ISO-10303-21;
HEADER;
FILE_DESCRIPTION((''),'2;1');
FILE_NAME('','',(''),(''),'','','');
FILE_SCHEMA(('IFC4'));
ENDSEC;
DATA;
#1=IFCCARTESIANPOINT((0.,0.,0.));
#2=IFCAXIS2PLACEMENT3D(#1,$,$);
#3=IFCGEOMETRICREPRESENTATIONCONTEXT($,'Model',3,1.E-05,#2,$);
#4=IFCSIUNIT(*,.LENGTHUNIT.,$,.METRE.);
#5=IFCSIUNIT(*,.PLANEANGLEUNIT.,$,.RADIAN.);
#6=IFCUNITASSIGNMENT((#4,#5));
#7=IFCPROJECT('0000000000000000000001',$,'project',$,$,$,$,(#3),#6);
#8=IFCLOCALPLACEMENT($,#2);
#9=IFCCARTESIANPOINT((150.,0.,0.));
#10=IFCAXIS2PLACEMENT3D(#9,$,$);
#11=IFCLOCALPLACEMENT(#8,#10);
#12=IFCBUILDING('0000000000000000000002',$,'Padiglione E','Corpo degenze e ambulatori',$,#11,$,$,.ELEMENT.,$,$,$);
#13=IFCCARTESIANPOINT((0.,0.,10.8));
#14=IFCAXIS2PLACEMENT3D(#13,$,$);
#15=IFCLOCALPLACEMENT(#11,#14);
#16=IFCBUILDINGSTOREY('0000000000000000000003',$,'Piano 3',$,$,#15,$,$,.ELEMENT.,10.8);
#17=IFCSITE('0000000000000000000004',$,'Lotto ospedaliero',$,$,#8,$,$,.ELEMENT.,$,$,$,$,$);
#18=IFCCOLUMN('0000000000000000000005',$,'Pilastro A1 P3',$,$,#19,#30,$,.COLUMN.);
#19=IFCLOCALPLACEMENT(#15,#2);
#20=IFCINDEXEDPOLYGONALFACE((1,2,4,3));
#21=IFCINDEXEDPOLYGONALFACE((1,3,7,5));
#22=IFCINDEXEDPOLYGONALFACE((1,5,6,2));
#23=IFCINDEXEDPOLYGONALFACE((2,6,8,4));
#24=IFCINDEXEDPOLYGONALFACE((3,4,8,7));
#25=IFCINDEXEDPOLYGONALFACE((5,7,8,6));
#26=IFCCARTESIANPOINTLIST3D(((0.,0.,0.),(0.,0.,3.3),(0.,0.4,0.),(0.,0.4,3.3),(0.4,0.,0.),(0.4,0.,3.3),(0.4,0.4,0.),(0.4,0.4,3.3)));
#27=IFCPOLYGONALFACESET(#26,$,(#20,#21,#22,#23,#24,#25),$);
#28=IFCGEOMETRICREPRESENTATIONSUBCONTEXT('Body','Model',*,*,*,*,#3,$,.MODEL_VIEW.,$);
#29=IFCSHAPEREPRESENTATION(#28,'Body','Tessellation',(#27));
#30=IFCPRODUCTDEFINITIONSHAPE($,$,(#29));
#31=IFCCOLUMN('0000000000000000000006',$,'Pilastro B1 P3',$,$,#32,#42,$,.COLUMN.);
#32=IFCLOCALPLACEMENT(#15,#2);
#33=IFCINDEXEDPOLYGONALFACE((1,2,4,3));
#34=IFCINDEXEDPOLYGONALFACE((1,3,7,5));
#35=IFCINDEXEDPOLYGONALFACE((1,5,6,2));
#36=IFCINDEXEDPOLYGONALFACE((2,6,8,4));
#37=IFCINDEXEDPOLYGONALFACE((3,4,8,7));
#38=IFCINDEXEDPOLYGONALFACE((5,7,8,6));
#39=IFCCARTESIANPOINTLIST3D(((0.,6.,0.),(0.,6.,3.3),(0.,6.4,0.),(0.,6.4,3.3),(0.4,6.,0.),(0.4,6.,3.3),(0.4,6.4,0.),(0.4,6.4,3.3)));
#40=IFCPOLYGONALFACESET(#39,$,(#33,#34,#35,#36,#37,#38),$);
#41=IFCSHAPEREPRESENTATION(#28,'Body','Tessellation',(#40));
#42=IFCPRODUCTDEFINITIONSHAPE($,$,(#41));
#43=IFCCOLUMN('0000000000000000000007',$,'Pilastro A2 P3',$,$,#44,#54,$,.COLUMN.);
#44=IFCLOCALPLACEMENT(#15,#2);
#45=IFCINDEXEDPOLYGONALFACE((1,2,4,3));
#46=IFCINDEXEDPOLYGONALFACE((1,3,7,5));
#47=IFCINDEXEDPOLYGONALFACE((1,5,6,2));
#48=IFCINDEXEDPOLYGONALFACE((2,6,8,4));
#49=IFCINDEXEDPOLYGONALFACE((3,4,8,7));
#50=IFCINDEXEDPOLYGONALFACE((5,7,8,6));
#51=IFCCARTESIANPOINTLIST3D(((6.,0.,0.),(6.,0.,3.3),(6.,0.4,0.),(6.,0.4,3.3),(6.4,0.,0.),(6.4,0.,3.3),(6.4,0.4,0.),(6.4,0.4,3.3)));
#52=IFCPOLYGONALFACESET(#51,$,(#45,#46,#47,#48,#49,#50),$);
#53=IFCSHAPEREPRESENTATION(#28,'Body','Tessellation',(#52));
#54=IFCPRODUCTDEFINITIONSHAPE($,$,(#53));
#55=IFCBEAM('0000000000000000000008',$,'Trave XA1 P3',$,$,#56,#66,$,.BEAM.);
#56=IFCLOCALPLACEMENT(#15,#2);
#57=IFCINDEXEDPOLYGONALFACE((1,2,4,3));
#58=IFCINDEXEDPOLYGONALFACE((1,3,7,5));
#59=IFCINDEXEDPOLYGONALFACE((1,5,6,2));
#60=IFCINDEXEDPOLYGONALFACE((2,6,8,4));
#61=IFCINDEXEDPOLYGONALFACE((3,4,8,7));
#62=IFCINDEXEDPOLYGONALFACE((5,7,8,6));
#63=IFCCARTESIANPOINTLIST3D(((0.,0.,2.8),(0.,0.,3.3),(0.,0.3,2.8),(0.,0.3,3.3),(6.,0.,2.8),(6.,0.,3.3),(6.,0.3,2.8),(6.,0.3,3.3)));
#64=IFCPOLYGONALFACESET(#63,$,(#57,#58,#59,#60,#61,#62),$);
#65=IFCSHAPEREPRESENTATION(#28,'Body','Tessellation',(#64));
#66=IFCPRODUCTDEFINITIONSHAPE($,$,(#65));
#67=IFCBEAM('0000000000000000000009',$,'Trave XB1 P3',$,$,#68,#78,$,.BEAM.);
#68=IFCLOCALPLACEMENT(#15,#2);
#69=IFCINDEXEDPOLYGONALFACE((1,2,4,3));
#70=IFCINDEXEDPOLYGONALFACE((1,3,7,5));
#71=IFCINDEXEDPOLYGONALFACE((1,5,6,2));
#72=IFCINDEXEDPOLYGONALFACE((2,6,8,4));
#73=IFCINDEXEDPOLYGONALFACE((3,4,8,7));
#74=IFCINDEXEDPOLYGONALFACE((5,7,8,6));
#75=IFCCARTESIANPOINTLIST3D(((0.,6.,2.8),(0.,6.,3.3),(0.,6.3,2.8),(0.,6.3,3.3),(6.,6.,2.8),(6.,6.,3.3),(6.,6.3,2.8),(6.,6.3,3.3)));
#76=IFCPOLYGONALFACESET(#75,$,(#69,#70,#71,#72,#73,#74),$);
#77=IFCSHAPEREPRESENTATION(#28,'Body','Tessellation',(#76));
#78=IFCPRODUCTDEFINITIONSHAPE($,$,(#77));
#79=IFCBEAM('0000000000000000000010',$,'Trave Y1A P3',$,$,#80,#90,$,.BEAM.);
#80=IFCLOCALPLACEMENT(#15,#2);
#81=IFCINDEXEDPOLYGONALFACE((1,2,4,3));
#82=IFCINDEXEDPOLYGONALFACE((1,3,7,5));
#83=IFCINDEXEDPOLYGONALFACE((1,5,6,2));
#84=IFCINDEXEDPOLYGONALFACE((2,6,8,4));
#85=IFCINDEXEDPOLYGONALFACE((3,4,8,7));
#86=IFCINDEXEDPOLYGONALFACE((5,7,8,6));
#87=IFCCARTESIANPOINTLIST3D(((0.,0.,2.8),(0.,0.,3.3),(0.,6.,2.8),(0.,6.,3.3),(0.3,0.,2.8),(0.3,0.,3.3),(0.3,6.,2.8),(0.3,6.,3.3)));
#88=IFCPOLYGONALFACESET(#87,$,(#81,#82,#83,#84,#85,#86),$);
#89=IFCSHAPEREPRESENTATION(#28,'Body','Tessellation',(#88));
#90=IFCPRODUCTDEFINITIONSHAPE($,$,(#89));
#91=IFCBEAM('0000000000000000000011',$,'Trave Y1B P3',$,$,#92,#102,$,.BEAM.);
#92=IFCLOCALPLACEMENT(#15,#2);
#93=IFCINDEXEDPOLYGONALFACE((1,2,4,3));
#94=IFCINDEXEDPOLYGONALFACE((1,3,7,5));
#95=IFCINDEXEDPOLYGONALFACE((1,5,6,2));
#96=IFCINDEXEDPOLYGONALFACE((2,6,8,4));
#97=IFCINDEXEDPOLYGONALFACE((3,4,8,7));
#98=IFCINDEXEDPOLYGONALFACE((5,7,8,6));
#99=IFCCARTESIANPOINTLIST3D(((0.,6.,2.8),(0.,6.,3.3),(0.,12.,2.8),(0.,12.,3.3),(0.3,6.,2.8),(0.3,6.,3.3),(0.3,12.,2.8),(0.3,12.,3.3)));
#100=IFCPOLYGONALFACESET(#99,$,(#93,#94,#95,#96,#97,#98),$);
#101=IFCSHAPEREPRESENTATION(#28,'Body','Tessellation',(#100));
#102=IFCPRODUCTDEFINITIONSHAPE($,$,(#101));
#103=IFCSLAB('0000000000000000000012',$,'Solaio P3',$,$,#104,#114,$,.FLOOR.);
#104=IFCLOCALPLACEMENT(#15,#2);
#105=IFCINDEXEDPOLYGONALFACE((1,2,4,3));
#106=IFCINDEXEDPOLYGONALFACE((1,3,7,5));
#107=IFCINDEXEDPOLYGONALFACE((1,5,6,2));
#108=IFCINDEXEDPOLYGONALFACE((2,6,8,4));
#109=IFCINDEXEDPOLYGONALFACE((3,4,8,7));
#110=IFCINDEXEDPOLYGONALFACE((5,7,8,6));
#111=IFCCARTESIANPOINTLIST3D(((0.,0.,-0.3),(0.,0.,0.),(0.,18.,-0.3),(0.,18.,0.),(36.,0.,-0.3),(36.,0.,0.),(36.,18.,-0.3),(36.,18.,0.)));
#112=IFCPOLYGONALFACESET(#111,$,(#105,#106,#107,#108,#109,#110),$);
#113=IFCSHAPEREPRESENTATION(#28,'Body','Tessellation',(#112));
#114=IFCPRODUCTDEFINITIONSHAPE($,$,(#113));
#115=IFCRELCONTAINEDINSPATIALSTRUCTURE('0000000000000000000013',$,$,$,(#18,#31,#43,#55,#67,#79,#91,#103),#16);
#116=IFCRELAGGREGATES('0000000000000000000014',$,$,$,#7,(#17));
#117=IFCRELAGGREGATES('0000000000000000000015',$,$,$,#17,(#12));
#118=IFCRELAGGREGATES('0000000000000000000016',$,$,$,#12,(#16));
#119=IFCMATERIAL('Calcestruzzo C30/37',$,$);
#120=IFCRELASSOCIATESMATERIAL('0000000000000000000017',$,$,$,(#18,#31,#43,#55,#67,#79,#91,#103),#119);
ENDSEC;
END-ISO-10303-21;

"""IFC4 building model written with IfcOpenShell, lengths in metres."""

from ifc_helpers import new_model, si_unit, frame, frame_2d, origin, place, context, subcontext, project, spatial, rectangle, extrude, material, element, save


model = new_model("IFC4")

# Units and contexts
model_context = context("Model", 3, precision=1e-05, world=origin())
body_context = subcontext(model_context, "Body", "Model", "MODEL_VIEW")
ifc_project = project(units=[si_unit("LENGTHUNIT", "METRE"), si_unit("PLANEANGLEUNIT", "RADIAN")], contexts=[model_context])

# Site, building, storey
site_placement = place(None, origin())
site = spatial("IfcSite", under=ifc_project, at=site_placement, Name="Lotto ospedaliero", CompositionType="ELEMENT")
building_placement = place(site_placement, frame((150.0, 0.0, 0.0)))
building = spatial("IfcBuilding", under=site, at=building_placement, Name="Padiglione E", Description="Corpo degenze e ambulatori", CompositionType="ELEMENT")
storey_placement = place(building_placement, frame((0.0, 0.0, 10.8)))
storey = spatial("IfcBuildingStorey", under=building, at=storey_placement, Name="Piano 3", CompositionType="ELEMENT", Elevation=10.8)

# Columns
ifc_material_1 = material(Name="Calcestruzzo C30/37")
for number, where, name in (
    (1, (0.0, 0.0, 0.0), "Pilastro A1 P3"),
    (2, (0.0, 6.0, 0.0), "Pilastro B1 P3"),
    (3, (6.0, 0.0, 0.0), "Pilastro A2 P3"),
):
    element("IfcColumn", number, at=place(storey_placement, frame(where)), inside=storey, material=ifc_material_1, Name=name, PredefinedType="COLUMN", context=body_context, shape_type="SweptSolid", body=[
        extrude(rectangle(XDim=0.4, YDim=0.4, at=frame_2d((0.2, 0.2))), origin(), (0.0, 0.0, 1.0), 3.3),
    ])

# Beams
for number, where, name in (
    (4, (0.0, 0.0, 2.8), "Trave XA1 P3"),
    (5, (0.0, 6.0, 2.8), "Trave XB1 P3"),
):
    element("IfcBeam", number, at=place(storey_placement, frame(where)), inside=storey, material=ifc_material_1, Name=name, PredefinedType="BEAM", context=body_context, shape_type="SweptSolid", body=[
        extrude(rectangle(XDim=6.0, YDim=0.3, at=frame_2d((3.0, 0.15))), origin(), (0.0, 0.0, 1.0), 0.5),
    ])
for number, where, name in (
    (6, (0.0, 0.0, 2.8), "Trave Y1A P3"),
    (7, (0.0, 6.0, 2.8), "Trave Y1B P3"),
):
    element("IfcBeam", number, at=place(storey_placement, frame(where)), inside=storey, material=ifc_material_1, Name=name, PredefinedType="BEAM", context=body_context, shape_type="SweptSolid", body=[
        extrude(rectangle(XDim=0.3, YDim=6.0, at=frame_2d((0.15, 3.0))), origin(), (0.0, 0.0, 1.0), 0.5),
    ])

# Slab
slab_placement = place(storey_placement, frame((0.0, 0.0, -0.3)))
element("IfcSlab", 8, at=slab_placement, inside=storey, material=ifc_material_1, Name="Solaio P3", PredefinedType="FLOOR", context=body_context, shape_type="SweptSolid", body=[
    extrude(rectangle(XDim=36.0, YDim=18.0, at=frame_2d((18.0, 9.0))), origin(), (0.0, 0.0, 1.0), 0.3),
])

save(model, "model.ifc")
